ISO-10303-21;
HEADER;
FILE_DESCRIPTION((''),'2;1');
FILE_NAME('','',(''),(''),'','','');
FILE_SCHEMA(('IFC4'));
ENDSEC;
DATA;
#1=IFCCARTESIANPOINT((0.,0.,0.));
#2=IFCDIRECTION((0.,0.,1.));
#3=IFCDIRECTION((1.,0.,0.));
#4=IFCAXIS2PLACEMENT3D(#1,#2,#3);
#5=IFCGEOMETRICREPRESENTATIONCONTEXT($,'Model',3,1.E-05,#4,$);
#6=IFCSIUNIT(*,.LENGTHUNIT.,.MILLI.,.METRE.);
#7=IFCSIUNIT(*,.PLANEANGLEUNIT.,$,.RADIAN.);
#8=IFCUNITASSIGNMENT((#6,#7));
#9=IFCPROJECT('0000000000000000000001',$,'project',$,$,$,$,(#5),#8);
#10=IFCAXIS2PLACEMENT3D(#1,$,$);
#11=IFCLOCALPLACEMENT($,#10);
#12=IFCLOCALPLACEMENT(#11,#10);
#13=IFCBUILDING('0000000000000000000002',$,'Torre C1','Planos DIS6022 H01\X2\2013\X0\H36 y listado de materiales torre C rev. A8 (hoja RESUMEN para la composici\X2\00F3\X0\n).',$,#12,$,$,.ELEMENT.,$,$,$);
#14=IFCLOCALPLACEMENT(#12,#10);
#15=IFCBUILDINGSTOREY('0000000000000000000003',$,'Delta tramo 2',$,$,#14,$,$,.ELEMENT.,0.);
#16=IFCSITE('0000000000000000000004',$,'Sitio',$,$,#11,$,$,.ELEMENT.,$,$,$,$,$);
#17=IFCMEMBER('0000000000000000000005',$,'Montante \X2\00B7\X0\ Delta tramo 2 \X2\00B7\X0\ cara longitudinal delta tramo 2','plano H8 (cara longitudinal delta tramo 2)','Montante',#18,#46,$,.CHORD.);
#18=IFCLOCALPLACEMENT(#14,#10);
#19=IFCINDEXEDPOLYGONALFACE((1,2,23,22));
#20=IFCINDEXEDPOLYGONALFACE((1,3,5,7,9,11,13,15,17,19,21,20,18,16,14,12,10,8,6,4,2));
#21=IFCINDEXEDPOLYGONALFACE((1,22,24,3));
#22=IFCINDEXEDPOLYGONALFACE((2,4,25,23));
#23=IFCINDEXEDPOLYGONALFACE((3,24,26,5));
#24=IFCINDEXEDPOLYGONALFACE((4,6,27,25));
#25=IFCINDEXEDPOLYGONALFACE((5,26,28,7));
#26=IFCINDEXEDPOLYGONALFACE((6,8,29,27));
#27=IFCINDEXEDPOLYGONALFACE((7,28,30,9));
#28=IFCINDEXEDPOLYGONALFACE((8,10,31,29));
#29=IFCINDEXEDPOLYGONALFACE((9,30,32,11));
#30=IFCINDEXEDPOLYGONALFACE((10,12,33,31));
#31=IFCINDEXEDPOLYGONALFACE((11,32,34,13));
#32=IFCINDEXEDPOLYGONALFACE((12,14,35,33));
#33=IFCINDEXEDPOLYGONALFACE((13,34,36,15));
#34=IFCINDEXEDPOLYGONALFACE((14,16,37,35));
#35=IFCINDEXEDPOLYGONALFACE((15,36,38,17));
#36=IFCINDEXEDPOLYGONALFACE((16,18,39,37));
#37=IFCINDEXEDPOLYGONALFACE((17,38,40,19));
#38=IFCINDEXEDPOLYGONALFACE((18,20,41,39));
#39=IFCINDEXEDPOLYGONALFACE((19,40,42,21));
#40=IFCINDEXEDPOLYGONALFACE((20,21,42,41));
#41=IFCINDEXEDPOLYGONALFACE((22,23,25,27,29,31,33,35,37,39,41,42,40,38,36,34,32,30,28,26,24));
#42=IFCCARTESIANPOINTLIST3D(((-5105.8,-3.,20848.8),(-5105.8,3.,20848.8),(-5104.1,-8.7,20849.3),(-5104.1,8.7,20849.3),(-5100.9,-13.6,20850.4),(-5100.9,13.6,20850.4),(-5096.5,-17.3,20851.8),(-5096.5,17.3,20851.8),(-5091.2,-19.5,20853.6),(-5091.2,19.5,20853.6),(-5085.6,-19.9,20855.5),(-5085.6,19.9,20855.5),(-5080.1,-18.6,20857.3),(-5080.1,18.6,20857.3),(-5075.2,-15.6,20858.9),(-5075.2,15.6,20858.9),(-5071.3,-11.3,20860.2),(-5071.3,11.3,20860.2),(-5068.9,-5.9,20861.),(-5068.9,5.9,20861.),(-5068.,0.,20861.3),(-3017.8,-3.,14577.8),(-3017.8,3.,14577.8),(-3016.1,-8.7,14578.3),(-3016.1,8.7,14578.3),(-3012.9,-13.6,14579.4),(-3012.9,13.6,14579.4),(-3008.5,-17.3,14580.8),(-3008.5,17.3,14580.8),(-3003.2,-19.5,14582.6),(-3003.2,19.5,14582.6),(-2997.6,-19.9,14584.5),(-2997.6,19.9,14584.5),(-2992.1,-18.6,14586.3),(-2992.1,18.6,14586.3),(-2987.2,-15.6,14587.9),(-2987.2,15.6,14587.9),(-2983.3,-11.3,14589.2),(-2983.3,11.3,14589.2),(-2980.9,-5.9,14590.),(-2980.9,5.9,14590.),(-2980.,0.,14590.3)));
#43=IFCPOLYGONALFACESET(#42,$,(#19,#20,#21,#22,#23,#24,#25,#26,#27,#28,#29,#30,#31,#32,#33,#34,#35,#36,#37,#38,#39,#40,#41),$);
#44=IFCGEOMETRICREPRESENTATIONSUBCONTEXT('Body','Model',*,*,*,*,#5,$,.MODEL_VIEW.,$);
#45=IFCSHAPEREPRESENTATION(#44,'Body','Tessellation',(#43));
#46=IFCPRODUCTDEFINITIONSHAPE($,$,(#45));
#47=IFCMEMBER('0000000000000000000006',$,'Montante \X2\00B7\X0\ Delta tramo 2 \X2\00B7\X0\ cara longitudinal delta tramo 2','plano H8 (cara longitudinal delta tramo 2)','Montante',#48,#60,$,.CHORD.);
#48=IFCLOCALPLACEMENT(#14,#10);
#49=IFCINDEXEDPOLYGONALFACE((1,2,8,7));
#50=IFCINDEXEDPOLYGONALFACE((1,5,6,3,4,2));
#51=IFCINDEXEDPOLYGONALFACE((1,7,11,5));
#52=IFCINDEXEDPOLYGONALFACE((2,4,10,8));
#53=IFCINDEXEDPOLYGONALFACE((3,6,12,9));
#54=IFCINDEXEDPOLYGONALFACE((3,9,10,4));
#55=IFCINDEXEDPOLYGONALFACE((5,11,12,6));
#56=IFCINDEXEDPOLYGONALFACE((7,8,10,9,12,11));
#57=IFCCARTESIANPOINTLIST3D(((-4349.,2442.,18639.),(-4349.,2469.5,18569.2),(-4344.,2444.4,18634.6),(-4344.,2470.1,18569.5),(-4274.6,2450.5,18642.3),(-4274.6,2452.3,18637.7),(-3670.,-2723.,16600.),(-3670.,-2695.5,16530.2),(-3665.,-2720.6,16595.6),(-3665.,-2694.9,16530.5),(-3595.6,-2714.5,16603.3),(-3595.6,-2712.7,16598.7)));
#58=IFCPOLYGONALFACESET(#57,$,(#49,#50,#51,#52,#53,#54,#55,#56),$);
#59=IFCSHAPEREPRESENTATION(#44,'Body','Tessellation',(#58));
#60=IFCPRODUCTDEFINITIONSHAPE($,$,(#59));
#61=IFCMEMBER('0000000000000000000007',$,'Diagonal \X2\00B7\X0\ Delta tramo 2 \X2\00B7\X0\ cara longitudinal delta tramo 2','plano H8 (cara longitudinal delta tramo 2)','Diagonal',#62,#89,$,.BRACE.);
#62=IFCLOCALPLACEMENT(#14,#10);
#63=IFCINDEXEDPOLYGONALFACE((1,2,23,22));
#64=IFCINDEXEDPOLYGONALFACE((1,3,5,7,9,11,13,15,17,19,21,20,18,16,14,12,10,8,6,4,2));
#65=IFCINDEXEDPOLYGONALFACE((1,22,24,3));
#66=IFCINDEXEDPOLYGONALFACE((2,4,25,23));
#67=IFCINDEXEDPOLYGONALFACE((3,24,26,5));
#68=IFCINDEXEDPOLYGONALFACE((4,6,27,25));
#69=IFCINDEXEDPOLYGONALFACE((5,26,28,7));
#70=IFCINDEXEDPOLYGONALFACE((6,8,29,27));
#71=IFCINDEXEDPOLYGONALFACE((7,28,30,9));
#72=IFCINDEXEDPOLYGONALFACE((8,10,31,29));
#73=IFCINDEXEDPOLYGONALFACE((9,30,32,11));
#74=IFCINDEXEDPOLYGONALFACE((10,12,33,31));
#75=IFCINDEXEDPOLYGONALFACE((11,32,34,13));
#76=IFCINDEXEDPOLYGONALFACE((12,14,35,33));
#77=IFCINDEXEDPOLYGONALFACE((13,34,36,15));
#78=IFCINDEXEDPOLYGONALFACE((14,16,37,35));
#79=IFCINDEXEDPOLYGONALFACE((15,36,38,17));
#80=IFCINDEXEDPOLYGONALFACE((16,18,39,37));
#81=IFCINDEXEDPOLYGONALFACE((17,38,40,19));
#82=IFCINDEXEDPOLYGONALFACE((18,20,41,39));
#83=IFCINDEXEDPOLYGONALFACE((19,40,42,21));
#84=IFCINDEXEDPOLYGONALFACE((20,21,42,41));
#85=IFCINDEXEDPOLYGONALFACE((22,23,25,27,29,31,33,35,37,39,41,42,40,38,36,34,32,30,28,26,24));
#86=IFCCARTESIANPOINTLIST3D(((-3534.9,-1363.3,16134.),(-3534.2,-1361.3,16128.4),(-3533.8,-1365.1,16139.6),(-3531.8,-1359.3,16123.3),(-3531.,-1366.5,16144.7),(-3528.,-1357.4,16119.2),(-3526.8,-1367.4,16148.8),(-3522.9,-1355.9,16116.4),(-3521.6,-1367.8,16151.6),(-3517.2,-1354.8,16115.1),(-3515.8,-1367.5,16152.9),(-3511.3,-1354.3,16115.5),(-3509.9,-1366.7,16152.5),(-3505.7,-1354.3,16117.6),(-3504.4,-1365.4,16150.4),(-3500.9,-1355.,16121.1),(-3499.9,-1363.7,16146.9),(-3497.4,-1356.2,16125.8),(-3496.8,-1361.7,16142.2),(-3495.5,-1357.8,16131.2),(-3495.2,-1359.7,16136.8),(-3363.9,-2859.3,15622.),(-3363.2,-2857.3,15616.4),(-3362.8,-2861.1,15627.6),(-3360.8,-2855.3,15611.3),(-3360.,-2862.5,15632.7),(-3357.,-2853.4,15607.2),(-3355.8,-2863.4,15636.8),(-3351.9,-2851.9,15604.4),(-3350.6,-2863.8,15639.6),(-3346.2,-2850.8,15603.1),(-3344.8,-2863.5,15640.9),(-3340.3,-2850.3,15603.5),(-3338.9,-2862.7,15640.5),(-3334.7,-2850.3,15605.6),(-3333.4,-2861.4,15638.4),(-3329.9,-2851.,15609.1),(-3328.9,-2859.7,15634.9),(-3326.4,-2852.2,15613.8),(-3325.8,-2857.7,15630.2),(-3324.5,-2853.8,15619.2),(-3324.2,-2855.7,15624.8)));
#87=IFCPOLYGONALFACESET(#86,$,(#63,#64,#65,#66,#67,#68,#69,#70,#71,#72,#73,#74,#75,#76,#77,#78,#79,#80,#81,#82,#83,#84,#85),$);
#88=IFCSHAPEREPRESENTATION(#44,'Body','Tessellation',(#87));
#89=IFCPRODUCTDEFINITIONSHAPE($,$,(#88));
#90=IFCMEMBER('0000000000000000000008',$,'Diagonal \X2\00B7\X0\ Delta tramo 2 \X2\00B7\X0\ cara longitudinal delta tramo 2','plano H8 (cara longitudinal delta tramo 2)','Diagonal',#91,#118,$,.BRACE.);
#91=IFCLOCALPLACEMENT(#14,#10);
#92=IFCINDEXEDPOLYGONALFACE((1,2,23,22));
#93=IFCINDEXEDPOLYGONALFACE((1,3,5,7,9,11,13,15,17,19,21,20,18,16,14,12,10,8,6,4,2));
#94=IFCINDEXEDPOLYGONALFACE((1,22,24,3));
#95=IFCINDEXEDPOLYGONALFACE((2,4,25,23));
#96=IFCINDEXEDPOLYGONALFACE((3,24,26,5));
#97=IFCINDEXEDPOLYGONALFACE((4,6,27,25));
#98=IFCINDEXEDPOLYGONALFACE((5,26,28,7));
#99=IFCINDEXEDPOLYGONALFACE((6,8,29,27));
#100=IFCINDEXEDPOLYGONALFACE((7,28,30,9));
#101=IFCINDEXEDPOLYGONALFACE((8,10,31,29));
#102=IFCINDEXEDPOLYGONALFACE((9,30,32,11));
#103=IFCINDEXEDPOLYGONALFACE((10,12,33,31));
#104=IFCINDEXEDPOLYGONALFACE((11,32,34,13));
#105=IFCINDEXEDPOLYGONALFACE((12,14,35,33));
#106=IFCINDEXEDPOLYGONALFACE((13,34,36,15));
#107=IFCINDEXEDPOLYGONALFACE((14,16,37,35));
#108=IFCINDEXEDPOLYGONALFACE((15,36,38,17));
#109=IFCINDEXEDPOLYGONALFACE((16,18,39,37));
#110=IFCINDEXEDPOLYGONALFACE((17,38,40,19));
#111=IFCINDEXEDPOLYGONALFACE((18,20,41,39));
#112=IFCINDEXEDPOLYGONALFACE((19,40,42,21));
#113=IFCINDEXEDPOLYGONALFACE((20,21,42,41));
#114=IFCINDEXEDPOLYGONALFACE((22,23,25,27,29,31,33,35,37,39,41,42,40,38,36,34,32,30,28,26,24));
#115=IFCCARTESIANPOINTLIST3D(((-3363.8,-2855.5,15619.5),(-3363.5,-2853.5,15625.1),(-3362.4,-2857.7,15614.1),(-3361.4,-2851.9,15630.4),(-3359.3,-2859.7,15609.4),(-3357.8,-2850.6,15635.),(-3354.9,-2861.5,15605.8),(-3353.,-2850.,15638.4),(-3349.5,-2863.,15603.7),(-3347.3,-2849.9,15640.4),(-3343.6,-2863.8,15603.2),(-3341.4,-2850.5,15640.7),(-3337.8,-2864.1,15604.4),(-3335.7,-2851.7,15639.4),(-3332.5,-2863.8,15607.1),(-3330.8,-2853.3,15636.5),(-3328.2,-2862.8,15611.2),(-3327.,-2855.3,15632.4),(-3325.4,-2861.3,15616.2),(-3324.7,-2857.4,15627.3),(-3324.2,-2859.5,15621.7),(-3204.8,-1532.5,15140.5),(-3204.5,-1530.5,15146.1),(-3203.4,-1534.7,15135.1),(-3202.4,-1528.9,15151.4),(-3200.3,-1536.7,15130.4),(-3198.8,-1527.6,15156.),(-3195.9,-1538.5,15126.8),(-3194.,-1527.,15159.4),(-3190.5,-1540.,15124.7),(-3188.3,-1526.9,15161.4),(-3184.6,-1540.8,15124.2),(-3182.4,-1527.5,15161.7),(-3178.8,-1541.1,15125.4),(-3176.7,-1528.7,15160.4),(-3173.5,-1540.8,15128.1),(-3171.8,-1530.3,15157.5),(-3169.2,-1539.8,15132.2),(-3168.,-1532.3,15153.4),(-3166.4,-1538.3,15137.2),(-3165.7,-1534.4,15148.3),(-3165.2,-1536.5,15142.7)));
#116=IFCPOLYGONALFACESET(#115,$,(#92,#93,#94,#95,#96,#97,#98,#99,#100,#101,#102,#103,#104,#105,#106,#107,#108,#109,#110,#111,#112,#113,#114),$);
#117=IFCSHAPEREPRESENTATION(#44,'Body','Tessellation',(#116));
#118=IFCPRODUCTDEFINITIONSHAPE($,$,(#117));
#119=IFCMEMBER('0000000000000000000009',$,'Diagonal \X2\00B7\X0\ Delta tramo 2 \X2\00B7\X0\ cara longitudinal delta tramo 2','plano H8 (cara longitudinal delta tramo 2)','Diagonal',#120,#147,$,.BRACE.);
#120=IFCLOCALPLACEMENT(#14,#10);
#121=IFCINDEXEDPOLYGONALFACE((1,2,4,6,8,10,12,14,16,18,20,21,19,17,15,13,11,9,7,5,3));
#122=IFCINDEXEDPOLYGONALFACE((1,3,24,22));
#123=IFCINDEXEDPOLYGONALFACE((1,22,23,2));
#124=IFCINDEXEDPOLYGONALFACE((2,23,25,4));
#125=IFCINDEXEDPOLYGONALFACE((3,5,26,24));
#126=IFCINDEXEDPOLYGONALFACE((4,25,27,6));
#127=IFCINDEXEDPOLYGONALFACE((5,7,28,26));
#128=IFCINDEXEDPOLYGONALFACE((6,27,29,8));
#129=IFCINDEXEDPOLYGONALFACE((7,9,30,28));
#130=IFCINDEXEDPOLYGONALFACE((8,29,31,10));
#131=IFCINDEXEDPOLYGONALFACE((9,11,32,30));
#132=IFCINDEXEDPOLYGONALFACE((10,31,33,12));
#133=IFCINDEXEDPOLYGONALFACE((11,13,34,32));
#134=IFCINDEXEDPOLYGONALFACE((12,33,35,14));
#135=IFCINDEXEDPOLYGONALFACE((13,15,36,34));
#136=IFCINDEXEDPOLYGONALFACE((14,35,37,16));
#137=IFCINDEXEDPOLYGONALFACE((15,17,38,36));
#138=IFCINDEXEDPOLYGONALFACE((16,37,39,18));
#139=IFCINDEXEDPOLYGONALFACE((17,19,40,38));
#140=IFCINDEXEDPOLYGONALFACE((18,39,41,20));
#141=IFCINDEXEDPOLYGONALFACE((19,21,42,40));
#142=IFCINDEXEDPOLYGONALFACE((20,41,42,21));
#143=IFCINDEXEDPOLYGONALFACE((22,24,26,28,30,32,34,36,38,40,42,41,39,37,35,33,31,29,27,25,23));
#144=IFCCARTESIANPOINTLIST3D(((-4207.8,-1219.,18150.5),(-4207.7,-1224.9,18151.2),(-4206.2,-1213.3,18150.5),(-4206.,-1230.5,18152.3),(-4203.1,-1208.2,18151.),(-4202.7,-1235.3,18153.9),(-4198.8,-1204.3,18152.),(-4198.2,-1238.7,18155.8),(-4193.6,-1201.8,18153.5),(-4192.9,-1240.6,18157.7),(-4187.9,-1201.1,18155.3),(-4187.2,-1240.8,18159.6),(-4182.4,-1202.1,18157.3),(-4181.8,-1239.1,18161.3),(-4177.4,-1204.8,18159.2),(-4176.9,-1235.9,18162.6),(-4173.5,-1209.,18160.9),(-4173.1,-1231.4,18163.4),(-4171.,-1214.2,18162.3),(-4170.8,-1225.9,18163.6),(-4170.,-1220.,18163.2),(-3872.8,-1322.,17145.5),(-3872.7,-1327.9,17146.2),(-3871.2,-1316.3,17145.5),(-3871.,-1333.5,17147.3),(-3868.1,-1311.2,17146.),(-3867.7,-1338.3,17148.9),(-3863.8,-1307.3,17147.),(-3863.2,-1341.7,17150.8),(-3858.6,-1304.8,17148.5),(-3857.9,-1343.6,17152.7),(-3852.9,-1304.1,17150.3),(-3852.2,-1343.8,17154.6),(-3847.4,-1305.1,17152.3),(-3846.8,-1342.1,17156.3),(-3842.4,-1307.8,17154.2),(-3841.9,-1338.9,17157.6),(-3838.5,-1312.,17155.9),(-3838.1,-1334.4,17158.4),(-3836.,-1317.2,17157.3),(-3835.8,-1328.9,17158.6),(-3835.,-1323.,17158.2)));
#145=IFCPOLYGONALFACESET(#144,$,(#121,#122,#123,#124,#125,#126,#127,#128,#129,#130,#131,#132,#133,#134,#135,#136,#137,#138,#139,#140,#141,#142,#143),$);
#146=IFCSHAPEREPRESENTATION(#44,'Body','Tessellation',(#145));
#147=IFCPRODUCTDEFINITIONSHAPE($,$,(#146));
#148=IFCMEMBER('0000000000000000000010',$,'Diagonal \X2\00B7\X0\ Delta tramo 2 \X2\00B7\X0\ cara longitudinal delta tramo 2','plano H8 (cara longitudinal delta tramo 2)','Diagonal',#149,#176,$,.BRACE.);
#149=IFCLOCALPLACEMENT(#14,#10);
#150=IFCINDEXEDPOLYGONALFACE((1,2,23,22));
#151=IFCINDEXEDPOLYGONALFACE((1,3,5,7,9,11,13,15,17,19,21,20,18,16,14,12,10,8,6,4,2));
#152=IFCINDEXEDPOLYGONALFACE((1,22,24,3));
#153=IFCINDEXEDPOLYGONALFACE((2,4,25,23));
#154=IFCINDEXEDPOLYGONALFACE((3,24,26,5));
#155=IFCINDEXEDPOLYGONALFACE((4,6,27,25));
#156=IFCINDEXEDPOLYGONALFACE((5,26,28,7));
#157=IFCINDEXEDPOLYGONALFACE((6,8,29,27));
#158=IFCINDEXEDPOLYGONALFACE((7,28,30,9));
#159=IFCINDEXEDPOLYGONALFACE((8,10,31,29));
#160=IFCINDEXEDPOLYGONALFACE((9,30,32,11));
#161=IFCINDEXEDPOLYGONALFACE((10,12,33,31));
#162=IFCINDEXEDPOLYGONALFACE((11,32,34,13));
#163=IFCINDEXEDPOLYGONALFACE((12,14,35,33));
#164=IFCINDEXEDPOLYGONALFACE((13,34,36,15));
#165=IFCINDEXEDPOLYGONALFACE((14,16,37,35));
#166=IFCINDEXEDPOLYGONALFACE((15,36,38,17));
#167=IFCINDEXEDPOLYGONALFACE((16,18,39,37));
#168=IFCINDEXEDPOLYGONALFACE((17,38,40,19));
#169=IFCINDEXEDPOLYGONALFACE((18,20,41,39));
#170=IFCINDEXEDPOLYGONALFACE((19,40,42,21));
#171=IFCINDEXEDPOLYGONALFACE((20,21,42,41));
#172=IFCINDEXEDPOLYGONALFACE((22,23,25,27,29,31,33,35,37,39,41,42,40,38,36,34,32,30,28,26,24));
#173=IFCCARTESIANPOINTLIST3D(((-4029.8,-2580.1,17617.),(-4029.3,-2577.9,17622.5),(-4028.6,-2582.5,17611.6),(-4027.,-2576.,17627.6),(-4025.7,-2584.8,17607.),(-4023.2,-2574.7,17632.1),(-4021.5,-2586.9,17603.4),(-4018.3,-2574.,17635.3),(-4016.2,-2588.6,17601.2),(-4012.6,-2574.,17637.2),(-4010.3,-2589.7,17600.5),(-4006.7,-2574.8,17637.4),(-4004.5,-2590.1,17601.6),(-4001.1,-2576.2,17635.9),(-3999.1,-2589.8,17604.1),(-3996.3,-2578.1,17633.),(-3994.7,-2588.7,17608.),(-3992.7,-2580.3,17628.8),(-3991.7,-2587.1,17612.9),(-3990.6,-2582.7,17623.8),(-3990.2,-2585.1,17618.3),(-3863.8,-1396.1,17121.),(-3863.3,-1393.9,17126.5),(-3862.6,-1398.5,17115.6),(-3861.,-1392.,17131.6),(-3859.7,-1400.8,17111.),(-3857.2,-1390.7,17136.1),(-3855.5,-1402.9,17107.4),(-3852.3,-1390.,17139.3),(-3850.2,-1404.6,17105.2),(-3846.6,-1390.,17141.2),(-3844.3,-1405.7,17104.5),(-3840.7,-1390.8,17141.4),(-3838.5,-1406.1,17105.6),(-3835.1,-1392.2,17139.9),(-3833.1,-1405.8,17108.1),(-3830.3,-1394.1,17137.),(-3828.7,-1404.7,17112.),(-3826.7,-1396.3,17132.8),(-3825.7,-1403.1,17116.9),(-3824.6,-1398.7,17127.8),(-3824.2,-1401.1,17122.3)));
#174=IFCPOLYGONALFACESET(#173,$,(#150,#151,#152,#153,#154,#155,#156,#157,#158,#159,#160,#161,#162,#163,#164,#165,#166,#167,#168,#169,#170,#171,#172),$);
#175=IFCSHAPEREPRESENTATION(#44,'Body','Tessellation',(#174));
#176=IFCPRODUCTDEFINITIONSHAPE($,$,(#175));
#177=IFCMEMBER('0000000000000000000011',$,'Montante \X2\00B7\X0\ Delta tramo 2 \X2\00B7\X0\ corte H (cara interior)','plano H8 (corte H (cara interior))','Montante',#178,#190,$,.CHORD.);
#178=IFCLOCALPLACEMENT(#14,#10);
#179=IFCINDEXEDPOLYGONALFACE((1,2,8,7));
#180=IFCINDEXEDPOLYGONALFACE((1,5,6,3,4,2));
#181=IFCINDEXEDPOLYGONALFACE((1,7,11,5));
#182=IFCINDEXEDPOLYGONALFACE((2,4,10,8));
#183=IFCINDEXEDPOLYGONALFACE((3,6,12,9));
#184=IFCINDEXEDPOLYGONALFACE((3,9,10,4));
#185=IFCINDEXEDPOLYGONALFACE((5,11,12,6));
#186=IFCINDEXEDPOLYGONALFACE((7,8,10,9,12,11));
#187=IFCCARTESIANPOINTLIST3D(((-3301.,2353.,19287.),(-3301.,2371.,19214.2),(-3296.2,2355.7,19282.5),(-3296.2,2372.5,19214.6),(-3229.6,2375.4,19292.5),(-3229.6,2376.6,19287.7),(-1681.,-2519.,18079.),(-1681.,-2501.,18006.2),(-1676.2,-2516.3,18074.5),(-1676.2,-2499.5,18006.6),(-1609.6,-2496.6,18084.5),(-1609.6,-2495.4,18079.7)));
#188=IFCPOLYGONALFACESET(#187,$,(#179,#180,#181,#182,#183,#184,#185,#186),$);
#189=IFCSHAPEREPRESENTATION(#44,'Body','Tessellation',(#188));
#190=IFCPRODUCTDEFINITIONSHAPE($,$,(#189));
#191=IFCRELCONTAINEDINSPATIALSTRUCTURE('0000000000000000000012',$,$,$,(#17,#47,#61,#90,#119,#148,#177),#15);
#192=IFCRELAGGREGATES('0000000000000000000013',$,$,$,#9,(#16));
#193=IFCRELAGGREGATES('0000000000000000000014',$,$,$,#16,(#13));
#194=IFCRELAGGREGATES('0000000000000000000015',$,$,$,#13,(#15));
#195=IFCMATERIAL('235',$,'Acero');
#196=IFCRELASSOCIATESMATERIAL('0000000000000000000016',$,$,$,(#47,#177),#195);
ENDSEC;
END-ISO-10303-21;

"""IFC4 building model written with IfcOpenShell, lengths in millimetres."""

from ifc_helpers import new_model, si_unit, frame, frame_2d, origin, origin_with_axes, place, context, subcontext, project, spatial, circle, l_section, extrude, material, element, save


model = new_model("IFC4")

# Units and contexts
model_context = context("Model", 3, precision=1e-05, world=origin_with_axes())
body_context = subcontext(model_context, "Body", "Model", "MODEL_VIEW")
ifc_project = project(units=[si_unit("LENGTHUNIT", "METRE", prefix="MILLI"), si_unit("PLANEANGLEUNIT", "RADIAN")], contexts=[model_context])

# Site, building, storey
site_placement = place(None, origin())
site = spatial("IfcSite", under=ifc_project, at=site_placement, Name="Sitio", CompositionType="ELEMENT")
building_placement = place(site_placement, origin())
building = spatial("IfcBuilding", under=site, at=building_placement, Name="Torre C1", Description="Planos DIS6022 H01–H36 y listado de materiales torre C rev. A8 (hoja RESUMEN para la composición).", CompositionType="ELEMENT")
storey_placement = place(building_placement, origin())
storey = spatial("IfcBuildingStorey", under=building, at=storey_placement, Name="Delta tramo 2", CompositionType="ELEMENT", Elevation=0.0)

# Members
member_1_placement = place(storey_placement, frame((-2999.0, 0.0, 14584.0), z_axis=(-0.31591, 0.0, 0.948789), x_axis=(0.948789, 0.0, 0.31591)))
element("IfcMember", 1, at=member_1_placement, inside=storey, Name="Montante · Delta tramo 2 · cara longitudinal delta tramo 2", Description="plano H8 (cara longitudinal delta tramo 2)", ObjectType="Montante", PredefinedType="CHORD", context=body_context, shape_type="SweptSolid", body=[
    extrude(circle(Radius=20.0), None, (0.0, 0.0, 1.0), 6609.5),
])
ifc_material = material(Name="235", Category="Acero")
member_2_placement = place(storey_placement, frame((-3670.0, -2723.0, 16600.0), z_axis=(-0.121374, 0.923267, 0.36448), x_axis=(0.992607, 0.112896, 0.044568)))
element("IfcMember", 2, at=member_2_placement, inside=storey, material=ifc_material, Name="Montante · Delta tramo 2 · cara longitudinal delta tramo 2", Description="plano H8 (cara longitudinal delta tramo 2)", ObjectType="Montante", PredefinedType="CHORD", context=body_context, shape_type="SweptSolid", body=[
    extrude(l_section(Depth=75.0, Width=75.0, Thickness=5.0, at=frame_2d((37.5, 37.5))), None, (0.0, 0.0, 1.0), 5594.3),
])
member_3_placement = place(storey_placement, frame((-3515.0, -1361.0, 16134.0), z_axis=(0.10752, -0.940639, -0.32193), x_axis=(0.977009, 0.159928, -0.140983)))
element("IfcMember", 3, at=member_3_placement, inside=storey, Name="Diagonal · Delta tramo 2 · cara longitudinal delta tramo 2", Description="plano H8 (cara longitudinal delta tramo 2)", ObjectType="Diagonal", PredefinedType="BRACE", context=body_context, shape_type="SweptSolid", body=[
    extrude(circle(Radius=20.0), None, (0.0, 0.0, 1.0), 1590.4),
])
member_4_placement = place(storey_placement, frame((-3344.0, -2857.0, 15622.0), z_axis=(0.112288, 0.934323, -0.338277), x_axis=(0.964427, -0.020485, 0.263553)))
element("IfcMember", 4, at=member_4_placement, inside=storey, Name="Diagonal · Delta tramo 2 · cara longitudinal delta tramo 2", Description="plano H8 (cara longitudinal delta tramo 2)", ObjectType="Diagonal", PredefinedType="BRACE", context=body_context, shape_type="SweptSolid", body=[
    extrude(circle(Radius=20.0), None, (0.0, 0.0, 1.0), 1416.0),
])
member_5_placement = place(storey_placement, frame((-3854.0, -1324.0, 17152.0), z_axis=(-0.314744, 0.096772, 0.944231), x_axis=(0.901869, 0.340631, 0.265712)))
element("IfcMember", 5, at=member_5_placement, inside=storey, Name="Diagonal · Delta tramo 2 · cara longitudinal delta tramo 2", Description="plano H8 (cara longitudinal delta tramo 2)", ObjectType="Diagonal", PredefinedType="BRACE", context=body_context, shape_type="SweptSolid", body=[
    extrude(circle(Radius=20.0), None, (0.0, 0.0, 1.0), 1064.4),
])
member_6_placement = place(storey_placement, frame((-4010.0, -2582.0, 17619.0), z_axis=(0.128246, 0.914721, -0.383194), x_axis=(0.970547, -0.036302, 0.238162)))
element("IfcMember", 6, at=member_6_placement, inside=storey, Name="Diagonal · Delta tramo 2 · cara longitudinal delta tramo 2", Description="plano H8 (cara longitudinal delta tramo 2)", ObjectType="Diagonal", PredefinedType="BRACE", context=body_context, shape_type="SweptSolid", body=[
    extrude(circle(Radius=20.0), None, (0.0, 0.0, 1.0), 1294.4),
])
member_7_placement = place(storey_placement, frame((-1681.0, -2519.0, 18079.0), z_axis=(-0.30714, 0.923694, 0.229028), x_axis=(0.951664, 0.298113, 0.073916)))
element("IfcMember", 7, at=member_7_placement, inside=storey, material=ifc_material, Name="Montante · Delta tramo 2 · corte H (cara interior)", Description="plano H8 (corte H (cara interior))", ObjectType="Montante", PredefinedType="CHORD", context=body_context, shape_type="SweptSolid", body=[
    extrude(l_section(Depth=75.0, Width=75.0, Thickness=5.0, at=frame_2d((37.5, 37.5))), None, (0.0, 0.0, 1.0), 5274.5),
])

save(model, "model.ifc")
